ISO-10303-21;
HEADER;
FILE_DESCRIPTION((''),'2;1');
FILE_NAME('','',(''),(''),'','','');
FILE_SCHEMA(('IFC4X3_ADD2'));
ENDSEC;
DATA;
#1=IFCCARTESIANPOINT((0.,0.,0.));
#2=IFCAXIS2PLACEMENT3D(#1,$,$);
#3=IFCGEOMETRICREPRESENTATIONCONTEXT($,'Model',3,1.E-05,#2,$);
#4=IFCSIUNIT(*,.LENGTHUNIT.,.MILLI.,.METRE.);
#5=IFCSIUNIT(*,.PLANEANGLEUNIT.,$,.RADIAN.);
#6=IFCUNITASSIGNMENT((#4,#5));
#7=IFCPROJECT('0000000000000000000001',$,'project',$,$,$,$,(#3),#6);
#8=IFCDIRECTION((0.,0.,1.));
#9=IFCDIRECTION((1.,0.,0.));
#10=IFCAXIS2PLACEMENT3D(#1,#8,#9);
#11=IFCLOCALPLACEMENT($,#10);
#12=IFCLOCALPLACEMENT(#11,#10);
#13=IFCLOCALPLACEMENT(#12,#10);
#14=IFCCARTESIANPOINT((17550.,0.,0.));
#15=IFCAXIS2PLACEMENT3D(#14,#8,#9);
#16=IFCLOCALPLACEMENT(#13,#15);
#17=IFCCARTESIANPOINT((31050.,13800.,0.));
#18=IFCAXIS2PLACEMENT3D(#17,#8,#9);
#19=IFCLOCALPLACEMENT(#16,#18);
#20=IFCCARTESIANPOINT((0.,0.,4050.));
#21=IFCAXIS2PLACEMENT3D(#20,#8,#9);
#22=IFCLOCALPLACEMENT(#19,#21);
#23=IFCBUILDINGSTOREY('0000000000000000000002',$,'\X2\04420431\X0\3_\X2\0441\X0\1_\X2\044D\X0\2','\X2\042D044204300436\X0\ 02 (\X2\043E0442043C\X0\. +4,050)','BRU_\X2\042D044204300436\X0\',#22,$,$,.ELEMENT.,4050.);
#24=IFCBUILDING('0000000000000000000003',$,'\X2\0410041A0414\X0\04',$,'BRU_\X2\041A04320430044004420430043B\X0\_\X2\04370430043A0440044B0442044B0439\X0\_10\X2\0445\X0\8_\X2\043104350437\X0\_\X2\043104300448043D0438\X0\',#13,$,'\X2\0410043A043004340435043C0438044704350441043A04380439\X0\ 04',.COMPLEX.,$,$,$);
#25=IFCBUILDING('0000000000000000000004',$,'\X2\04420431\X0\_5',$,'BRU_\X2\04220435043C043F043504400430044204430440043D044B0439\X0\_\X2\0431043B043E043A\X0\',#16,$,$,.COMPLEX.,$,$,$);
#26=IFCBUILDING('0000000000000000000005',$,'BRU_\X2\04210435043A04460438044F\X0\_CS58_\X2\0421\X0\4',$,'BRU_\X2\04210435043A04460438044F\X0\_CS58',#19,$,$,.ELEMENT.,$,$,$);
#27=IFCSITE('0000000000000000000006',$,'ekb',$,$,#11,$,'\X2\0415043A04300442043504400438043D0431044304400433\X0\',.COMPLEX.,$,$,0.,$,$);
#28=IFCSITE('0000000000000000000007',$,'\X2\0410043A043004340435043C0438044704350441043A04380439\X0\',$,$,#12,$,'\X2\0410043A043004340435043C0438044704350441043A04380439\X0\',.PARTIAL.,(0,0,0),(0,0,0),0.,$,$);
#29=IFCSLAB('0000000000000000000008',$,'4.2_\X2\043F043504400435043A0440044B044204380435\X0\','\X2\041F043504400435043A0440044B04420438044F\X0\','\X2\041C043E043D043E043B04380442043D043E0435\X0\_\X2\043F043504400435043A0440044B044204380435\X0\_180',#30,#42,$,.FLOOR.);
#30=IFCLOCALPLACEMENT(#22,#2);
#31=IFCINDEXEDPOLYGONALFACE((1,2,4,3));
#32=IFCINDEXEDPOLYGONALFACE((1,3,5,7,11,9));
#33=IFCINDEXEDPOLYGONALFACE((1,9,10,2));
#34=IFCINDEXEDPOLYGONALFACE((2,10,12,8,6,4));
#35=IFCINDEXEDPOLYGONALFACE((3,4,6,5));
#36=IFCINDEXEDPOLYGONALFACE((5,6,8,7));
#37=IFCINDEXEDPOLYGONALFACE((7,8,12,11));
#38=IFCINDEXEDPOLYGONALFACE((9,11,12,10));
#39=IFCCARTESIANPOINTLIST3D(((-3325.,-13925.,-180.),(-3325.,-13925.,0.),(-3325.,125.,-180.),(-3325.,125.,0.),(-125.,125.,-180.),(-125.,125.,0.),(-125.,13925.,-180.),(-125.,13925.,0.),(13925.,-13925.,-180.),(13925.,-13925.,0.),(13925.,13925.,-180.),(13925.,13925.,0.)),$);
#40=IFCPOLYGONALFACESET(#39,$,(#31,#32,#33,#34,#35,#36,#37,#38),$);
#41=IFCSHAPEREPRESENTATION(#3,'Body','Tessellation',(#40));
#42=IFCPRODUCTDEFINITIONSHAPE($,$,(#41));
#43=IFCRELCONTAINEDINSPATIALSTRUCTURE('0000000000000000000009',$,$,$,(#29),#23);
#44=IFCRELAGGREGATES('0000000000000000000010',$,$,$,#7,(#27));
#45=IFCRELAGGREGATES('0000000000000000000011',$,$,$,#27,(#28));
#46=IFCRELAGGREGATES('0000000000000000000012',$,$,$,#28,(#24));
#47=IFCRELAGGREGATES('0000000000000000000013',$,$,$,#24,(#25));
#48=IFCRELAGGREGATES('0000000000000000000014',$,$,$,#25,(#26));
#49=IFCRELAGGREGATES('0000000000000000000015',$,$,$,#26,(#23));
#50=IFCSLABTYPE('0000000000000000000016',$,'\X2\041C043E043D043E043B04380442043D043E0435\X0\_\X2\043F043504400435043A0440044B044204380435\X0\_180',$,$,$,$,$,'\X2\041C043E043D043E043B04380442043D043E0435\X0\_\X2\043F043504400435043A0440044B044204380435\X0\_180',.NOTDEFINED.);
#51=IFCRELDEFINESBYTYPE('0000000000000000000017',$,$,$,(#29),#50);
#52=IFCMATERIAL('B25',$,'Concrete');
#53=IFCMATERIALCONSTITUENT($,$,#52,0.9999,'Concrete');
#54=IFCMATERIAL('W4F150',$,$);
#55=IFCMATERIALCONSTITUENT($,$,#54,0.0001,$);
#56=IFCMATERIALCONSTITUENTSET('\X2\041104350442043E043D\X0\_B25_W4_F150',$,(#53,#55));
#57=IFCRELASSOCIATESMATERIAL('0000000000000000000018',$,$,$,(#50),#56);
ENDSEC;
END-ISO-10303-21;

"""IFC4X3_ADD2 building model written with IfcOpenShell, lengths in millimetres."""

from ifc_helpers import new_model, si_unit, frame, origin, origin_with_axes, place, context, project, spatial, polyline, outline, extrude, material, constituent, constituent_set, type_object, element, save


model = new_model("IFC4X3_ADD2")

# Units and contexts
model_context = context("Model", 3, precision=1e-05, world=origin())
ifc_project = project(units=[si_unit("LENGTHUNIT", "METRE", prefix="MILLI"), si_unit("PLANEANGLEUNIT", "RADIAN")], contexts=[model_context])

# Sites, buildings, storey
site_1_placement = place(None, origin_with_axes())
site_1 = spatial("IfcSite", under=ifc_project, at=site_1_placement, Name="ekb", LongName="Екатеринбург", CompositionType="COMPLEX", RefElevation=0.0)
site_2_placement = place(site_1_placement, origin_with_axes())
site_2 = spatial("IfcSite", under=site_1, at=site_2_placement, Name="Академический", LongName="Академический", CompositionType="PARTIAL", RefLatitude=(0, 0, 0), RefLongitude=(0, 0, 0), RefElevation=0.0)
building_1_placement = place(site_2_placement, origin_with_axes())
building_1 = spatial("IfcBuilding", under=site_2, at=building_1_placement, Name="АКД04", ObjectType="BRU_Квартал_закрытый_10х8_без_башни", LongName="Академический 04", CompositionType="COMPLEX")
building_2_placement = place(building_1_placement, frame((17550.0, 0.0, 0.0), z_axis=(0.0, 0.0, 1.0), x_axis=(1.0, 0.0, 0.0)))
building_2 = spatial("IfcBuilding", under=building_1, at=building_2_placement, Name="тб_5", ObjectType="BRU_Температурный_блок", CompositionType="COMPLEX")
building_3_placement = place(building_2_placement, frame((31050.0, 13800.0, 0.0), z_axis=(0.0, 0.0, 1.0), x_axis=(1.0, 0.0, 0.0)))
building_3 = spatial("IfcBuilding", under=building_2, at=building_3_placement, Name="BRU_Секция_CS58_С4", ObjectType="BRU_Секция_CS58", CompositionType="ELEMENT")
storey_placement = place(building_3_placement, frame((0.0, 0.0, 4050.0), z_axis=(0.0, 0.0, 1.0), x_axis=(1.0, 0.0, 0.0)))
storey = spatial("IfcBuildingStorey", under=building_3, at=storey_placement, Name="тб3_с1_э2", Description="Этаж 02 (отм. +4,050)", ObjectType="BRU_Этаж", CompositionType="ELEMENT", Elevation=4050.0)

# Shared definitions
ifc_material_1 = material(Name="B25", Category="Concrete")
ifc_material_2 = material(Name="W4F150")

# Slab
ifc_constituent_1 = constituent(ifc_material_1, Category="Concrete", fraction=0.9999)
ifc_constituent_2 = constituent(ifc_material_2, fraction=0.0001)
ifc_constituent_set_1 = constituent_set(constituents=[ifc_constituent_1, ifc_constituent_2], Name="Бетон_B25_W4_F150")
slab_type = type_object("IfcSlabType", Name="Монолитное_перекрытие_180", ElementType="Монолитное_перекрытие_180", PredefinedType="NOTDEFINED", material=ifc_constituent_set_1)
slab_placement = place(storey_placement, frame((0.0, 0.0, -180.0), z_axis=(0.0, 0.0, 1.0), x_axis=(1.0, 0.0, 0.0)))
element("IfcSlab", 1, at=slab_placement, inside=storey, type_object=slab_type, Name="4.2_перекрытие", Description="Перекрытия", ObjectType="Монолитное_перекрытие_180", PredefinedType="FLOOR", context=model_context, shape_type="SweptSolid", body=[
    extrude(outline(polyline([(13925.0, -13925.0), (13925.0, 13925.0), (-125.0, 13925.0), (-125.0, 125.0), (-3325.0, 125.0), (-3325.0, -13925.0), (13925.0, -13925.0)])), origin_with_axes(), (0.0, 0.0, 1.0), 180.0),
])

save(model, "model.ifc")
